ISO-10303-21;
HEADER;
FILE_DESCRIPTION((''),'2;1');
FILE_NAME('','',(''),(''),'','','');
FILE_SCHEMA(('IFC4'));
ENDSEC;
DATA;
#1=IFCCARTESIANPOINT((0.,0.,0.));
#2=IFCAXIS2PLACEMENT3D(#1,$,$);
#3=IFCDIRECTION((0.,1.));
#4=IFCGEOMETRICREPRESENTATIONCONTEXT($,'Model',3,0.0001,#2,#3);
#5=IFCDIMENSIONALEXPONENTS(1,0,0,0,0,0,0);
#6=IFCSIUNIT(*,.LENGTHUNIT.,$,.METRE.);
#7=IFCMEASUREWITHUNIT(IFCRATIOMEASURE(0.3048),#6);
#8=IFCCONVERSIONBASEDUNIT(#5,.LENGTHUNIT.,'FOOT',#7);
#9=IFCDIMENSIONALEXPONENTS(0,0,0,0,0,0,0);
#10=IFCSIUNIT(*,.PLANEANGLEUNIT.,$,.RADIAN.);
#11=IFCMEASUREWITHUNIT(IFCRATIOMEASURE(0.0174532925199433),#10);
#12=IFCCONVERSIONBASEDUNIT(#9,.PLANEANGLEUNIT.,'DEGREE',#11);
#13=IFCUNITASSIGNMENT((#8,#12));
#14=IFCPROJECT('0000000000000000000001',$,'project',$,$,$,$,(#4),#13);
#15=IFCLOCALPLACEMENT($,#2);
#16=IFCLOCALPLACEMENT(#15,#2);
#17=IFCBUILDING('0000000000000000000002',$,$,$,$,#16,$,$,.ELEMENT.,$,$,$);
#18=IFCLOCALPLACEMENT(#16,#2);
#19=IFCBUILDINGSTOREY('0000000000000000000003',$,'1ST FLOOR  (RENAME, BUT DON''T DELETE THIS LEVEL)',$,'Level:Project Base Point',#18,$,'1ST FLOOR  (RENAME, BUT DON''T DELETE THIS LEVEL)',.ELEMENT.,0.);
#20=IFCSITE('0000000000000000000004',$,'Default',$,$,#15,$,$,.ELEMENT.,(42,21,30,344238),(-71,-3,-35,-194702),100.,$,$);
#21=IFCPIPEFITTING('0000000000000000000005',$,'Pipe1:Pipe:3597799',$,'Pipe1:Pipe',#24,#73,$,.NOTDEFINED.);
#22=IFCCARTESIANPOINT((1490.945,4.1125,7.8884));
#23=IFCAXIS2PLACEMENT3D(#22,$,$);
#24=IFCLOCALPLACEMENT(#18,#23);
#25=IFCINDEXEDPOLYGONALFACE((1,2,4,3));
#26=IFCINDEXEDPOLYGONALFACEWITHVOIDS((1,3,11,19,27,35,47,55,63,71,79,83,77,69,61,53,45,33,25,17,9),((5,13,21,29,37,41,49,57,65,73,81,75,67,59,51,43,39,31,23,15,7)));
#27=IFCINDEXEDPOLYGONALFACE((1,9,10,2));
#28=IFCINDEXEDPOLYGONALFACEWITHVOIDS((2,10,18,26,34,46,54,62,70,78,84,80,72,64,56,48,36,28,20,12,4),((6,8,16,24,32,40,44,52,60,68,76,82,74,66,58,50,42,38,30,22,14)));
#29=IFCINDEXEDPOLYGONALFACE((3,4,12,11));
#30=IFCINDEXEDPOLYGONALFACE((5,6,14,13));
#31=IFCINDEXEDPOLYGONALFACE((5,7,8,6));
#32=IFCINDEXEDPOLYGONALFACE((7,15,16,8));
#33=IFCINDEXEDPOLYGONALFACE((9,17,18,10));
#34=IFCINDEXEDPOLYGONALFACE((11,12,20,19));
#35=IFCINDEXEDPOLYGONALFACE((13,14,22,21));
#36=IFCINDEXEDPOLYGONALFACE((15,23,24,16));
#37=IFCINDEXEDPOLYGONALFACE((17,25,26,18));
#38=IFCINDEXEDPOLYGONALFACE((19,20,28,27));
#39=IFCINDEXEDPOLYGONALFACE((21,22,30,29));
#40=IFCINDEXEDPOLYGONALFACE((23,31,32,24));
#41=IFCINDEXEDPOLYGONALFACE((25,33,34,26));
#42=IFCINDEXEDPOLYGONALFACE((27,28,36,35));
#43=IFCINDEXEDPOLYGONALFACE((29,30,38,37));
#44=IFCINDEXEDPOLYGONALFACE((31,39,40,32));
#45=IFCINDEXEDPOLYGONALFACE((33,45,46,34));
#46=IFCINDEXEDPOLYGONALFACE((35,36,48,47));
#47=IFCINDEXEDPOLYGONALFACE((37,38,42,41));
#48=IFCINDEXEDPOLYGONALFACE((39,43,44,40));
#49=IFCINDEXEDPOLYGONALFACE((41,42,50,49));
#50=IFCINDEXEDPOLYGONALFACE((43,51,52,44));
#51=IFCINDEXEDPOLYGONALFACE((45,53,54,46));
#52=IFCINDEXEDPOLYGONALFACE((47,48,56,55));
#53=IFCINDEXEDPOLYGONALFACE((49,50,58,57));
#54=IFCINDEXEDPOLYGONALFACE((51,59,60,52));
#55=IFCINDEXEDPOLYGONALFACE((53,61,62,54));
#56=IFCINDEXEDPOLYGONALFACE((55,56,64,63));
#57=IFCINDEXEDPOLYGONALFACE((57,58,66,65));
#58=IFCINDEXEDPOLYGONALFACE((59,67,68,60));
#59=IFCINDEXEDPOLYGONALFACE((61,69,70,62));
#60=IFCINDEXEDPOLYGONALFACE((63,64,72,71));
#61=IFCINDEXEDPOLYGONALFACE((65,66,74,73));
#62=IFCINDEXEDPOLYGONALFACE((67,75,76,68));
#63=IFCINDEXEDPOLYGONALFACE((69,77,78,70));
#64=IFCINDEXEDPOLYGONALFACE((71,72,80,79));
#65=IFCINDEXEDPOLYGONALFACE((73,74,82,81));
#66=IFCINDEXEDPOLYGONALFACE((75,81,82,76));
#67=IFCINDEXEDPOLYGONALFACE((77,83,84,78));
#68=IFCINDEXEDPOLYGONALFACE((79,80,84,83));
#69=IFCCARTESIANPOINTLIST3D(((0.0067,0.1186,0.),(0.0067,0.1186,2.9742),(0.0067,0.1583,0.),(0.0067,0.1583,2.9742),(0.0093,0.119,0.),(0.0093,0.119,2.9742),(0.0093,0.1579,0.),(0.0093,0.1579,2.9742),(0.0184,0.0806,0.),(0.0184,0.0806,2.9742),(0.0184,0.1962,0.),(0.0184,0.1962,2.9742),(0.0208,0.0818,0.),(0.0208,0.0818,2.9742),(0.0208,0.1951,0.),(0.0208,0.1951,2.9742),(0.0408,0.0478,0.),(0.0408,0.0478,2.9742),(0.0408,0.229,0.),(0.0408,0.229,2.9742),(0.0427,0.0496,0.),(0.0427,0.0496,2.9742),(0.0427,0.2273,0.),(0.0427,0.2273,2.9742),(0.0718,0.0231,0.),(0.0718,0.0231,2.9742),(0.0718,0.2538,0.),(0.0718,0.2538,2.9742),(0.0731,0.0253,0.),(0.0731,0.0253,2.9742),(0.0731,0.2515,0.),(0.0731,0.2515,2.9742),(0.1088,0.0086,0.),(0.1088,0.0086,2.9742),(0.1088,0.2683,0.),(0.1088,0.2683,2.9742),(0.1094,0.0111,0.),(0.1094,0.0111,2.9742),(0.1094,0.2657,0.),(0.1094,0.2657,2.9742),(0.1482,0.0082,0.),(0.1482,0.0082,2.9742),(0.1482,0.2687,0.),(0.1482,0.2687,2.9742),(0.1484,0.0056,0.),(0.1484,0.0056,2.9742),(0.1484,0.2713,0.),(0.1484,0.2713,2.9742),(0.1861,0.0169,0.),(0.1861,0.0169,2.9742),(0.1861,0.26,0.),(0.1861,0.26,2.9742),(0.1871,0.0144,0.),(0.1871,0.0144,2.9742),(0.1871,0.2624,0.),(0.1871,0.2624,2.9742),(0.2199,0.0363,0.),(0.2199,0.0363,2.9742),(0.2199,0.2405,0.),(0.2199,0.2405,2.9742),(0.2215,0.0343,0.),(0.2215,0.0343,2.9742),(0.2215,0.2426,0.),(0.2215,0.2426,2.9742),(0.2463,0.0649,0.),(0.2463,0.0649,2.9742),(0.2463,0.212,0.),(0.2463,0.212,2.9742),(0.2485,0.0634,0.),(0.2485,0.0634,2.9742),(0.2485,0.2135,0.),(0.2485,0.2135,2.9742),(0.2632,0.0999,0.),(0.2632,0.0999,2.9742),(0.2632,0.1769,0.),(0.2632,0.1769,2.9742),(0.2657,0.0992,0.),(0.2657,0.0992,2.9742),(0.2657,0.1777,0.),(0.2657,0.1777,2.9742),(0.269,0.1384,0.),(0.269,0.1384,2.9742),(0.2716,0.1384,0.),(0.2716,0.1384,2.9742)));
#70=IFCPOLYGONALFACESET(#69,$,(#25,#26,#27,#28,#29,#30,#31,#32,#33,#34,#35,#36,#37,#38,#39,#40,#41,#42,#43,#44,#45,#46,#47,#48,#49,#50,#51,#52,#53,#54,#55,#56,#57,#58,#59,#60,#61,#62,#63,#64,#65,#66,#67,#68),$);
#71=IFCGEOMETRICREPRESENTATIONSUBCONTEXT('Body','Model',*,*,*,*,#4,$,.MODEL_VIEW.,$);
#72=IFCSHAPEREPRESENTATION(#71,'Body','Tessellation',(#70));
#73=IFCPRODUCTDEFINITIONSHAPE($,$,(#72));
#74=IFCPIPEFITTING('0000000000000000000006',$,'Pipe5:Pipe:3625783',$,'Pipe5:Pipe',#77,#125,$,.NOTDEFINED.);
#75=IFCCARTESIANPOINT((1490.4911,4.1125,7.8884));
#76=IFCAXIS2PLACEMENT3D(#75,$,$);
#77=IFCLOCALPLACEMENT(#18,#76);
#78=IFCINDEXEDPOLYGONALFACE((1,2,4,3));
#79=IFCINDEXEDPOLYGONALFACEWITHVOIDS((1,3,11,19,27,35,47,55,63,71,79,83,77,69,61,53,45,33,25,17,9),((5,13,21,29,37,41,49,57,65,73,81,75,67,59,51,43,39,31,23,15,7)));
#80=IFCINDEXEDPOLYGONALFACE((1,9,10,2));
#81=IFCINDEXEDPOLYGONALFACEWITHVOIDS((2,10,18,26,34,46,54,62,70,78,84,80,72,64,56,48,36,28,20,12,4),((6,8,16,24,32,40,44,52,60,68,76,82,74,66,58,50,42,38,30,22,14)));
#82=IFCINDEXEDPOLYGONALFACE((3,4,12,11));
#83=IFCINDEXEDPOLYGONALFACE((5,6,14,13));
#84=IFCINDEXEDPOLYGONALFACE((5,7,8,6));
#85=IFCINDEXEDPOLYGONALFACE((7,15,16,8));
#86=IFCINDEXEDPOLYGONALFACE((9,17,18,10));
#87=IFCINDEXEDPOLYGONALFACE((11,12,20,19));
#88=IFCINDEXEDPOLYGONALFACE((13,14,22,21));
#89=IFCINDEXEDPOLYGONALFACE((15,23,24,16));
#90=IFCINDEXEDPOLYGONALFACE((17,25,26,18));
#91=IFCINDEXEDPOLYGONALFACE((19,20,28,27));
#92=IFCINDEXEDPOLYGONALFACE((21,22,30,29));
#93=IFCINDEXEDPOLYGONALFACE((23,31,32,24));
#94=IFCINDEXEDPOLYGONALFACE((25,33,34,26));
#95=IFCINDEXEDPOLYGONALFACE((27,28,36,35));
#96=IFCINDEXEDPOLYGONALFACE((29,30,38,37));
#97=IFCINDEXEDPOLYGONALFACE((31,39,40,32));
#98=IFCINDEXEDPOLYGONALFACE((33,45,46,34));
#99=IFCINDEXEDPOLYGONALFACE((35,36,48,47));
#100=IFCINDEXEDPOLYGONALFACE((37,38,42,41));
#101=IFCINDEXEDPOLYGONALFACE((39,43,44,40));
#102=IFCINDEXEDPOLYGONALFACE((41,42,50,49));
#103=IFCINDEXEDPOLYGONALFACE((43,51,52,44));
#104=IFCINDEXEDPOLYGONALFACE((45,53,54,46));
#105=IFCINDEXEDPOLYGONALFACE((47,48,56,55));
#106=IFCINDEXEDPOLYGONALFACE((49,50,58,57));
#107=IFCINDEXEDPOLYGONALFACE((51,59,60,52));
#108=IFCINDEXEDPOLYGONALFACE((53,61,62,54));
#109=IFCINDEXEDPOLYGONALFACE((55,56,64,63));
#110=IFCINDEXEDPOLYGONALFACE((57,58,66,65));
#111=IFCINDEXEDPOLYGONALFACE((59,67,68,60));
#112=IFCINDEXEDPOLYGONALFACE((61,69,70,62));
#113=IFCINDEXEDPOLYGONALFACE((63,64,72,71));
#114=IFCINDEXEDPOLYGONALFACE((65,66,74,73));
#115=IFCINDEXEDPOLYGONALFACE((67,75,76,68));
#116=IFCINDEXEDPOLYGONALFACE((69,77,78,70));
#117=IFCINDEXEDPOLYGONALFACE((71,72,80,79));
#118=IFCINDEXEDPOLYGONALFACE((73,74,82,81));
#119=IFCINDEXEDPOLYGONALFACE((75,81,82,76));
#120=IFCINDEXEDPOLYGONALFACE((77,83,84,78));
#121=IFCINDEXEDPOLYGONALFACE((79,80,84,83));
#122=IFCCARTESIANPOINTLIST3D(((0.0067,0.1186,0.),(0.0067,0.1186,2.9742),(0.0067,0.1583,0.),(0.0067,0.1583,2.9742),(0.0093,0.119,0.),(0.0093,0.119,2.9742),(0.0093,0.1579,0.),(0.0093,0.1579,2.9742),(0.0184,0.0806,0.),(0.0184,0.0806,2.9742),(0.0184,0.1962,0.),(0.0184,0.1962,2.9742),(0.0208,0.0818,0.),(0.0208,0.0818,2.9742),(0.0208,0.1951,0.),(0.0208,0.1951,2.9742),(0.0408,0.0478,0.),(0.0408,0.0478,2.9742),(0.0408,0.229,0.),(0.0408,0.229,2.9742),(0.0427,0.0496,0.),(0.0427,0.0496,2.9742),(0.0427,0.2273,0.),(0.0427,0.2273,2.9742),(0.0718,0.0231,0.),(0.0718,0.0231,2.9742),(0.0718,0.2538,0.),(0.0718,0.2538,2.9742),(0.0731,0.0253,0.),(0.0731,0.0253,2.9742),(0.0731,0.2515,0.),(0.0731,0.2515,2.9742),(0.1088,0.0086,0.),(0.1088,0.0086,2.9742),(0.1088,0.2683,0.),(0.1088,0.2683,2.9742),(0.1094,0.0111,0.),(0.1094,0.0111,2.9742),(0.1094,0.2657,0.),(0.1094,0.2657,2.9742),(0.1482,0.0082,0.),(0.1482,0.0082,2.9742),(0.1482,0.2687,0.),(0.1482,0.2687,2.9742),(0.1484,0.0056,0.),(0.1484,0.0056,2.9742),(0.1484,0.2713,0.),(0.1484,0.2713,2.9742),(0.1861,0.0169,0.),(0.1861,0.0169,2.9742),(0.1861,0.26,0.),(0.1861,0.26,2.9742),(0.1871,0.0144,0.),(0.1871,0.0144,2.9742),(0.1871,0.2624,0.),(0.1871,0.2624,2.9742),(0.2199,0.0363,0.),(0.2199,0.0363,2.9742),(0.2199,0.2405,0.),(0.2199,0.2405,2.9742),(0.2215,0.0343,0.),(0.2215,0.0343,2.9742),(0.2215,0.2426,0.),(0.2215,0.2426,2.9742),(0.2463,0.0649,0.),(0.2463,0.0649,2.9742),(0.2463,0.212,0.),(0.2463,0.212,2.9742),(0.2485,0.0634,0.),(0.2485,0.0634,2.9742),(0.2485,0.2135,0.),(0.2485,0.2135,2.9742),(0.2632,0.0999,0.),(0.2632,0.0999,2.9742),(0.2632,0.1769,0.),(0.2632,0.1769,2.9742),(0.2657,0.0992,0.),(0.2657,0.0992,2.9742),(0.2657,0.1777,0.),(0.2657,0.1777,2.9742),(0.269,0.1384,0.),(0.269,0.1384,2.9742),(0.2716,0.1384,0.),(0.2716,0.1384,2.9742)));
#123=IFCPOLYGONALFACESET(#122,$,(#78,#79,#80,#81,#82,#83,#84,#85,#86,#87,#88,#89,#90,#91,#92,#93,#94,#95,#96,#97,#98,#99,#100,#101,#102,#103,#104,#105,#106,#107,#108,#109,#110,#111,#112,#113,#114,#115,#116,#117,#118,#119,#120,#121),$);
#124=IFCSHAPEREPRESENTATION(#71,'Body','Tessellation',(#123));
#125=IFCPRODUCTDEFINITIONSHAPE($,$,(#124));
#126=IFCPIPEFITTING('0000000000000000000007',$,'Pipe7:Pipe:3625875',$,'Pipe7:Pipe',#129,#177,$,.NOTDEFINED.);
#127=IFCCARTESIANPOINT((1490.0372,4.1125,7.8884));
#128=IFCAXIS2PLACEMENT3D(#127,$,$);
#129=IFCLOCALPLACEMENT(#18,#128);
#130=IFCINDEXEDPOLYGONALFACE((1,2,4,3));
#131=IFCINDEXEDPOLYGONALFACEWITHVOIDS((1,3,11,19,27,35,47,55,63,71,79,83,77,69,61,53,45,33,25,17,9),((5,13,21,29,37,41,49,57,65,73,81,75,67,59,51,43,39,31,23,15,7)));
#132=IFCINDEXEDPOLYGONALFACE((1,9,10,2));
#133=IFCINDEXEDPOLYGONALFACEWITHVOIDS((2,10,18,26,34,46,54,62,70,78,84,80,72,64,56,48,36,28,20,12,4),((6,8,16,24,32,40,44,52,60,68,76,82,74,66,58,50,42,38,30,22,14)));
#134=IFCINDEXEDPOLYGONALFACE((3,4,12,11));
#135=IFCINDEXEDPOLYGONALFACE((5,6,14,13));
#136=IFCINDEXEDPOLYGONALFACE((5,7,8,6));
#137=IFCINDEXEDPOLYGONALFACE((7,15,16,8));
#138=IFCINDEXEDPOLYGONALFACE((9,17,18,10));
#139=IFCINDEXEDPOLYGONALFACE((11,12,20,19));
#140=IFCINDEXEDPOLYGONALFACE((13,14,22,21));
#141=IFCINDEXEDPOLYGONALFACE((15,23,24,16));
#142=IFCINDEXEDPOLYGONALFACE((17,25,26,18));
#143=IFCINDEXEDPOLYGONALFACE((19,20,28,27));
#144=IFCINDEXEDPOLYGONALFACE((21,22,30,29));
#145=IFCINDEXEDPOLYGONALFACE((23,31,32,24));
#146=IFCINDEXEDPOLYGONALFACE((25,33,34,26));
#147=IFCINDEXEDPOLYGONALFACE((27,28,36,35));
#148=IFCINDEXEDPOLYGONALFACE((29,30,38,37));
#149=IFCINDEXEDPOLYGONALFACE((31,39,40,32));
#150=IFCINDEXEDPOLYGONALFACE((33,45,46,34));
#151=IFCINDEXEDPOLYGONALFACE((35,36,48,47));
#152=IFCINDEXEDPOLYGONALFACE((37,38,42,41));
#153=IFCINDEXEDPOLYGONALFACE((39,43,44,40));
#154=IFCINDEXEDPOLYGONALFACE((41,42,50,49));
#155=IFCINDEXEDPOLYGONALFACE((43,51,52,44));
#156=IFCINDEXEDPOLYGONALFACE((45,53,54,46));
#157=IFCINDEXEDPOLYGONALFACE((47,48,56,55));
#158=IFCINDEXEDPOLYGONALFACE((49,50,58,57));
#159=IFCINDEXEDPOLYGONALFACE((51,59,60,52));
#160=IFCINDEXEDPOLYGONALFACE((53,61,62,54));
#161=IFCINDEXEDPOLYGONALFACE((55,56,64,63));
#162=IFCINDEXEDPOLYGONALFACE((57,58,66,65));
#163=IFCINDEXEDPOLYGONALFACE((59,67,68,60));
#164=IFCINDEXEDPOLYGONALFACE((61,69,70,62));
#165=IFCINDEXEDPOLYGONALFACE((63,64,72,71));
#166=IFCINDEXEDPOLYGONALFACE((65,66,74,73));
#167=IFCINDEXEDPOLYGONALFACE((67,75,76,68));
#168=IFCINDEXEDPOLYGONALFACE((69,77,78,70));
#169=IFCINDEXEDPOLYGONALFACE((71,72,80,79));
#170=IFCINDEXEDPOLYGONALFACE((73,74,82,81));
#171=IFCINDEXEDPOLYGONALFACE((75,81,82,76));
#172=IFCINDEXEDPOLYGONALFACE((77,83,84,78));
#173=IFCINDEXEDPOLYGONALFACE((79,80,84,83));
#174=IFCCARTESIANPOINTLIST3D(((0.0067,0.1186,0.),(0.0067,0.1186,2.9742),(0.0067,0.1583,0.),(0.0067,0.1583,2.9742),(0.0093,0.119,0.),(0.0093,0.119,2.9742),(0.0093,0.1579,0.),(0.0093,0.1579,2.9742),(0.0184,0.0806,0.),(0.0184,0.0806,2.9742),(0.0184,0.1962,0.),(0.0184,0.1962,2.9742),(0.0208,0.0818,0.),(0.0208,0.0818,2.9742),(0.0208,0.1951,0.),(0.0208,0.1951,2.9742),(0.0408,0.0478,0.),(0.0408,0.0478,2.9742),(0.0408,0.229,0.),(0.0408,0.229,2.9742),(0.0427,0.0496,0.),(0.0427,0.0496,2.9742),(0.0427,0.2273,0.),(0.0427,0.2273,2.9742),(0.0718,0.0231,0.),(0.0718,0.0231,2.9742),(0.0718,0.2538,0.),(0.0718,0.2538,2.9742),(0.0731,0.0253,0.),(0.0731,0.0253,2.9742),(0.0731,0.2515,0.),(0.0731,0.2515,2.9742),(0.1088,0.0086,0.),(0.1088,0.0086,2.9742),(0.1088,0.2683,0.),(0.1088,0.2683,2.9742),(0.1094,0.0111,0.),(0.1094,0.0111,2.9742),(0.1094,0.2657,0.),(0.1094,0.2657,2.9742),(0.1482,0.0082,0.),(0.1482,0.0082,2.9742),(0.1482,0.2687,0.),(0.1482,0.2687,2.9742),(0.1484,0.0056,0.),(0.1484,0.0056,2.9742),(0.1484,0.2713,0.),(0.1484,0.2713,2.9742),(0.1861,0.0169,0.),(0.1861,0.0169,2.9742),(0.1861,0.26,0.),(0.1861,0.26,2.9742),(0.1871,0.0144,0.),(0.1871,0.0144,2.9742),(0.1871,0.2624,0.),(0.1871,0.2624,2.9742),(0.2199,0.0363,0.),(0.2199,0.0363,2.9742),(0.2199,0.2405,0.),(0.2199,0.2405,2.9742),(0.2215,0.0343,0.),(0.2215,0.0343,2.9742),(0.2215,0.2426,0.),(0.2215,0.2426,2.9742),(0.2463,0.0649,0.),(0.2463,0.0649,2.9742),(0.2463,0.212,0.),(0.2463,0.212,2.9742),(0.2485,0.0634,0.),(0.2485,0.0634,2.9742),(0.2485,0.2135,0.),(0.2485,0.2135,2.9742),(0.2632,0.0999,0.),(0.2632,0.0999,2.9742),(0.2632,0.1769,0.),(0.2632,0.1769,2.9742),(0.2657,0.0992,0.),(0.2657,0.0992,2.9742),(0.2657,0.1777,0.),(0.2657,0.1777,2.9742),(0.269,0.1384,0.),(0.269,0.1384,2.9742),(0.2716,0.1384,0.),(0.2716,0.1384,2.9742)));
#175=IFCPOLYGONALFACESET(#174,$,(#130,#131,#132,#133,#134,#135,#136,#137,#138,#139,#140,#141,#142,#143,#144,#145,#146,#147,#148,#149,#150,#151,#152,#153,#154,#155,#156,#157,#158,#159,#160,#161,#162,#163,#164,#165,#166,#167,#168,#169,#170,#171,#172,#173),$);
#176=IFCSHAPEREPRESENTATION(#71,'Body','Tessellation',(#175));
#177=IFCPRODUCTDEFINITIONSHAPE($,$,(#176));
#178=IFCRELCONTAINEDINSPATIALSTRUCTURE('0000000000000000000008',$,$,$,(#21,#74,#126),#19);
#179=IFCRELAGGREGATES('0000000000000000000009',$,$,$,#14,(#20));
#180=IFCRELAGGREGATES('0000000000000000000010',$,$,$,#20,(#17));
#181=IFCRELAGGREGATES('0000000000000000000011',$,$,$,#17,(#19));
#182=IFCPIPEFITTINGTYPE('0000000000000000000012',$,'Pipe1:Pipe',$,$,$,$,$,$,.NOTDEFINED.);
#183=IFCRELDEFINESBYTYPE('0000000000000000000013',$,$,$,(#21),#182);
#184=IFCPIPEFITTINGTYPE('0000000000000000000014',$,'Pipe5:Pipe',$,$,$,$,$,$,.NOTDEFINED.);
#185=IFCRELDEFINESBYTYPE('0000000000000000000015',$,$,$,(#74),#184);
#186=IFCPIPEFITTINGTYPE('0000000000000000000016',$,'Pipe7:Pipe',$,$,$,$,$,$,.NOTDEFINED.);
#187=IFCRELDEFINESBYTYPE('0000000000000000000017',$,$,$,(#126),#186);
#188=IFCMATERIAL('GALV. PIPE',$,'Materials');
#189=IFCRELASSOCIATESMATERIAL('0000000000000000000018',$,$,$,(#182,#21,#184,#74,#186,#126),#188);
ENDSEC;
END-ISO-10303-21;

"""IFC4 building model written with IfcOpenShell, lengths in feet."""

from ifc_helpers import new_model, entity, si_unit, converted_unit, direction, frame, frame_2d, origin, place, context, subcontext, project, spatial, hollow_circle, extrude, source, transform, mapped, material, type_object, type_shapes, element, save


model = new_model("IFC4")

# Units and contexts
model_context = context("Model", 3, precision=0.0001, world=origin(), true_north=direction((0.0, 1.0)))
body_context = subcontext(model_context, "Body", "Model", "MODEL_VIEW")
ifc_project = project(units=[converted_unit("LENGTHUNIT", "FOOT", entity("IfcRatioMeasure", 0.3048), si_unit("LENGTHUNIT", "METRE"), dimensions=[1, 0, 0, 0, 0, 0, 0]), converted_unit("PLANEANGLEUNIT", "DEGREE", entity("IfcRatioMeasure", 0.0174532925199433), si_unit("PLANEANGLEUNIT", "RADIAN"), dimensions=[0, 0, 0, 0, 0, 0, 0])], contexts=[model_context])

# Site, building, storey
site_placement = place(None, origin())
site = spatial("IfcSite", under=ifc_project, at=site_placement, Name="Default", CompositionType="ELEMENT", RefLatitude=(42, 21, 30, 344238), RefLongitude=(-71, -3, -35, -194702), RefElevation=100.0)
building_placement = place(site_placement, origin())
building = spatial("IfcBuilding", under=site, at=building_placement, CompositionType="ELEMENT")
storey_placement = place(building_placement, origin())
storey = spatial("IfcBuildingStorey", under=building, at=storey_placement, Name="1ST FLOOR  (RENAME, BUT DON'T DELETE THIS LEVEL)", ObjectType="Level:Project Base Point", LongName="1ST FLOOR  (RENAME, BUT DON'T DELETE THIS LEVEL)", CompositionType="ELEMENT", Elevation=0.0)

# Pipe fitting
ifc_material_1 = material(Name="GALV. PIPE", Category="Materials")
pipe_fitting_type_1 = type_object("IfcPipeFittingType", Name="Pipe1:Pipe", PredefinedType="NOTDEFINED", material=ifc_material_1)
shared_shape_1 = source(origin(), body_context, "Body", "SweptSolid", [
    extrude(hollow_circle(Radius=0.1332, WallThickness=0.0026, at=frame_2d((0.0, 0.0), x_axis=(1.0, 0.0))), frame((0.1384, 0.1384, 0.0)), (0.0, 0.0, 1.0), 2.9742),
])
type_shapes(pipe_fitting_type_1, [shared_shape_1])
pipe_fitting_1_placement = place(storey_placement, frame((1490.945, 4.1125, 7.8884)))
element("IfcPipeFitting", 1, at=pipe_fitting_1_placement, inside=storey, type_object=pipe_fitting_type_1, material=ifc_material_1, Name="Pipe1:Pipe:3597799", ObjectType="Pipe1:Pipe", PredefinedType="NOTDEFINED", context=body_context, shape_type="MappedRepresentation", body=[
    mapped(shared_shape_1, transform((0.0, 0.0, 0.0), scale=1.0)),
])

# Pipe fitting
pipe_fitting_type_2 = type_object("IfcPipeFittingType", Name="Pipe5:Pipe", PredefinedType="NOTDEFINED", material=ifc_material_1)
shared_shape_2 = source(origin(), body_context, "Body", "SweptSolid", [
    extrude(hollow_circle(Radius=0.1332, WallThickness=0.0026, at=frame_2d((0.0, 0.0), x_axis=(1.0, 0.0))), frame((0.1384, 0.1384, 0.0)), (0.0, 0.0, 1.0), 2.9742),
])
type_shapes(pipe_fitting_type_2, [shared_shape_2])
pipe_fitting_2_placement = place(storey_placement, frame((1490.4911, 4.1125, 7.8884)))
element("IfcPipeFitting", 2, at=pipe_fitting_2_placement, inside=storey, type_object=pipe_fitting_type_2, material=ifc_material_1, Name="Pipe5:Pipe:3625783", ObjectType="Pipe5:Pipe", PredefinedType="NOTDEFINED", context=body_context, shape_type="MappedRepresentation", body=[
    mapped(shared_shape_2, transform((0.0, 0.0, 0.0), scale=1.0)),
])

# Pipe fitting
pipe_fitting_type_3 = type_object("IfcPipeFittingType", Name="Pipe7:Pipe", PredefinedType="NOTDEFINED", material=ifc_material_1)
shared_shape_3 = source(origin(), body_context, "Body", "SweptSolid", [
    extrude(hollow_circle(Radius=0.1332, WallThickness=0.0026, at=frame_2d((0.0, 0.0), x_axis=(1.0, 0.0))), frame((0.1384, 0.1384, 0.0)), (0.0, 0.0, 1.0), 2.9742),
])
type_shapes(pipe_fitting_type_3, [shared_shape_3])
pipe_fitting_3_placement = place(storey_placement, frame((1490.0372, 4.1125, 7.8884)))
element("IfcPipeFitting", 3, at=pipe_fitting_3_placement, inside=storey, type_object=pipe_fitting_type_3, material=ifc_material_1, Name="Pipe7:Pipe:3625875", ObjectType="Pipe7:Pipe", PredefinedType="NOTDEFINED", context=body_context, shape_type="MappedRepresentation", body=[
    mapped(shared_shape_3, transform((0.0, 0.0, 0.0), scale=1.0)),
])

save(model, "model.ifc")
